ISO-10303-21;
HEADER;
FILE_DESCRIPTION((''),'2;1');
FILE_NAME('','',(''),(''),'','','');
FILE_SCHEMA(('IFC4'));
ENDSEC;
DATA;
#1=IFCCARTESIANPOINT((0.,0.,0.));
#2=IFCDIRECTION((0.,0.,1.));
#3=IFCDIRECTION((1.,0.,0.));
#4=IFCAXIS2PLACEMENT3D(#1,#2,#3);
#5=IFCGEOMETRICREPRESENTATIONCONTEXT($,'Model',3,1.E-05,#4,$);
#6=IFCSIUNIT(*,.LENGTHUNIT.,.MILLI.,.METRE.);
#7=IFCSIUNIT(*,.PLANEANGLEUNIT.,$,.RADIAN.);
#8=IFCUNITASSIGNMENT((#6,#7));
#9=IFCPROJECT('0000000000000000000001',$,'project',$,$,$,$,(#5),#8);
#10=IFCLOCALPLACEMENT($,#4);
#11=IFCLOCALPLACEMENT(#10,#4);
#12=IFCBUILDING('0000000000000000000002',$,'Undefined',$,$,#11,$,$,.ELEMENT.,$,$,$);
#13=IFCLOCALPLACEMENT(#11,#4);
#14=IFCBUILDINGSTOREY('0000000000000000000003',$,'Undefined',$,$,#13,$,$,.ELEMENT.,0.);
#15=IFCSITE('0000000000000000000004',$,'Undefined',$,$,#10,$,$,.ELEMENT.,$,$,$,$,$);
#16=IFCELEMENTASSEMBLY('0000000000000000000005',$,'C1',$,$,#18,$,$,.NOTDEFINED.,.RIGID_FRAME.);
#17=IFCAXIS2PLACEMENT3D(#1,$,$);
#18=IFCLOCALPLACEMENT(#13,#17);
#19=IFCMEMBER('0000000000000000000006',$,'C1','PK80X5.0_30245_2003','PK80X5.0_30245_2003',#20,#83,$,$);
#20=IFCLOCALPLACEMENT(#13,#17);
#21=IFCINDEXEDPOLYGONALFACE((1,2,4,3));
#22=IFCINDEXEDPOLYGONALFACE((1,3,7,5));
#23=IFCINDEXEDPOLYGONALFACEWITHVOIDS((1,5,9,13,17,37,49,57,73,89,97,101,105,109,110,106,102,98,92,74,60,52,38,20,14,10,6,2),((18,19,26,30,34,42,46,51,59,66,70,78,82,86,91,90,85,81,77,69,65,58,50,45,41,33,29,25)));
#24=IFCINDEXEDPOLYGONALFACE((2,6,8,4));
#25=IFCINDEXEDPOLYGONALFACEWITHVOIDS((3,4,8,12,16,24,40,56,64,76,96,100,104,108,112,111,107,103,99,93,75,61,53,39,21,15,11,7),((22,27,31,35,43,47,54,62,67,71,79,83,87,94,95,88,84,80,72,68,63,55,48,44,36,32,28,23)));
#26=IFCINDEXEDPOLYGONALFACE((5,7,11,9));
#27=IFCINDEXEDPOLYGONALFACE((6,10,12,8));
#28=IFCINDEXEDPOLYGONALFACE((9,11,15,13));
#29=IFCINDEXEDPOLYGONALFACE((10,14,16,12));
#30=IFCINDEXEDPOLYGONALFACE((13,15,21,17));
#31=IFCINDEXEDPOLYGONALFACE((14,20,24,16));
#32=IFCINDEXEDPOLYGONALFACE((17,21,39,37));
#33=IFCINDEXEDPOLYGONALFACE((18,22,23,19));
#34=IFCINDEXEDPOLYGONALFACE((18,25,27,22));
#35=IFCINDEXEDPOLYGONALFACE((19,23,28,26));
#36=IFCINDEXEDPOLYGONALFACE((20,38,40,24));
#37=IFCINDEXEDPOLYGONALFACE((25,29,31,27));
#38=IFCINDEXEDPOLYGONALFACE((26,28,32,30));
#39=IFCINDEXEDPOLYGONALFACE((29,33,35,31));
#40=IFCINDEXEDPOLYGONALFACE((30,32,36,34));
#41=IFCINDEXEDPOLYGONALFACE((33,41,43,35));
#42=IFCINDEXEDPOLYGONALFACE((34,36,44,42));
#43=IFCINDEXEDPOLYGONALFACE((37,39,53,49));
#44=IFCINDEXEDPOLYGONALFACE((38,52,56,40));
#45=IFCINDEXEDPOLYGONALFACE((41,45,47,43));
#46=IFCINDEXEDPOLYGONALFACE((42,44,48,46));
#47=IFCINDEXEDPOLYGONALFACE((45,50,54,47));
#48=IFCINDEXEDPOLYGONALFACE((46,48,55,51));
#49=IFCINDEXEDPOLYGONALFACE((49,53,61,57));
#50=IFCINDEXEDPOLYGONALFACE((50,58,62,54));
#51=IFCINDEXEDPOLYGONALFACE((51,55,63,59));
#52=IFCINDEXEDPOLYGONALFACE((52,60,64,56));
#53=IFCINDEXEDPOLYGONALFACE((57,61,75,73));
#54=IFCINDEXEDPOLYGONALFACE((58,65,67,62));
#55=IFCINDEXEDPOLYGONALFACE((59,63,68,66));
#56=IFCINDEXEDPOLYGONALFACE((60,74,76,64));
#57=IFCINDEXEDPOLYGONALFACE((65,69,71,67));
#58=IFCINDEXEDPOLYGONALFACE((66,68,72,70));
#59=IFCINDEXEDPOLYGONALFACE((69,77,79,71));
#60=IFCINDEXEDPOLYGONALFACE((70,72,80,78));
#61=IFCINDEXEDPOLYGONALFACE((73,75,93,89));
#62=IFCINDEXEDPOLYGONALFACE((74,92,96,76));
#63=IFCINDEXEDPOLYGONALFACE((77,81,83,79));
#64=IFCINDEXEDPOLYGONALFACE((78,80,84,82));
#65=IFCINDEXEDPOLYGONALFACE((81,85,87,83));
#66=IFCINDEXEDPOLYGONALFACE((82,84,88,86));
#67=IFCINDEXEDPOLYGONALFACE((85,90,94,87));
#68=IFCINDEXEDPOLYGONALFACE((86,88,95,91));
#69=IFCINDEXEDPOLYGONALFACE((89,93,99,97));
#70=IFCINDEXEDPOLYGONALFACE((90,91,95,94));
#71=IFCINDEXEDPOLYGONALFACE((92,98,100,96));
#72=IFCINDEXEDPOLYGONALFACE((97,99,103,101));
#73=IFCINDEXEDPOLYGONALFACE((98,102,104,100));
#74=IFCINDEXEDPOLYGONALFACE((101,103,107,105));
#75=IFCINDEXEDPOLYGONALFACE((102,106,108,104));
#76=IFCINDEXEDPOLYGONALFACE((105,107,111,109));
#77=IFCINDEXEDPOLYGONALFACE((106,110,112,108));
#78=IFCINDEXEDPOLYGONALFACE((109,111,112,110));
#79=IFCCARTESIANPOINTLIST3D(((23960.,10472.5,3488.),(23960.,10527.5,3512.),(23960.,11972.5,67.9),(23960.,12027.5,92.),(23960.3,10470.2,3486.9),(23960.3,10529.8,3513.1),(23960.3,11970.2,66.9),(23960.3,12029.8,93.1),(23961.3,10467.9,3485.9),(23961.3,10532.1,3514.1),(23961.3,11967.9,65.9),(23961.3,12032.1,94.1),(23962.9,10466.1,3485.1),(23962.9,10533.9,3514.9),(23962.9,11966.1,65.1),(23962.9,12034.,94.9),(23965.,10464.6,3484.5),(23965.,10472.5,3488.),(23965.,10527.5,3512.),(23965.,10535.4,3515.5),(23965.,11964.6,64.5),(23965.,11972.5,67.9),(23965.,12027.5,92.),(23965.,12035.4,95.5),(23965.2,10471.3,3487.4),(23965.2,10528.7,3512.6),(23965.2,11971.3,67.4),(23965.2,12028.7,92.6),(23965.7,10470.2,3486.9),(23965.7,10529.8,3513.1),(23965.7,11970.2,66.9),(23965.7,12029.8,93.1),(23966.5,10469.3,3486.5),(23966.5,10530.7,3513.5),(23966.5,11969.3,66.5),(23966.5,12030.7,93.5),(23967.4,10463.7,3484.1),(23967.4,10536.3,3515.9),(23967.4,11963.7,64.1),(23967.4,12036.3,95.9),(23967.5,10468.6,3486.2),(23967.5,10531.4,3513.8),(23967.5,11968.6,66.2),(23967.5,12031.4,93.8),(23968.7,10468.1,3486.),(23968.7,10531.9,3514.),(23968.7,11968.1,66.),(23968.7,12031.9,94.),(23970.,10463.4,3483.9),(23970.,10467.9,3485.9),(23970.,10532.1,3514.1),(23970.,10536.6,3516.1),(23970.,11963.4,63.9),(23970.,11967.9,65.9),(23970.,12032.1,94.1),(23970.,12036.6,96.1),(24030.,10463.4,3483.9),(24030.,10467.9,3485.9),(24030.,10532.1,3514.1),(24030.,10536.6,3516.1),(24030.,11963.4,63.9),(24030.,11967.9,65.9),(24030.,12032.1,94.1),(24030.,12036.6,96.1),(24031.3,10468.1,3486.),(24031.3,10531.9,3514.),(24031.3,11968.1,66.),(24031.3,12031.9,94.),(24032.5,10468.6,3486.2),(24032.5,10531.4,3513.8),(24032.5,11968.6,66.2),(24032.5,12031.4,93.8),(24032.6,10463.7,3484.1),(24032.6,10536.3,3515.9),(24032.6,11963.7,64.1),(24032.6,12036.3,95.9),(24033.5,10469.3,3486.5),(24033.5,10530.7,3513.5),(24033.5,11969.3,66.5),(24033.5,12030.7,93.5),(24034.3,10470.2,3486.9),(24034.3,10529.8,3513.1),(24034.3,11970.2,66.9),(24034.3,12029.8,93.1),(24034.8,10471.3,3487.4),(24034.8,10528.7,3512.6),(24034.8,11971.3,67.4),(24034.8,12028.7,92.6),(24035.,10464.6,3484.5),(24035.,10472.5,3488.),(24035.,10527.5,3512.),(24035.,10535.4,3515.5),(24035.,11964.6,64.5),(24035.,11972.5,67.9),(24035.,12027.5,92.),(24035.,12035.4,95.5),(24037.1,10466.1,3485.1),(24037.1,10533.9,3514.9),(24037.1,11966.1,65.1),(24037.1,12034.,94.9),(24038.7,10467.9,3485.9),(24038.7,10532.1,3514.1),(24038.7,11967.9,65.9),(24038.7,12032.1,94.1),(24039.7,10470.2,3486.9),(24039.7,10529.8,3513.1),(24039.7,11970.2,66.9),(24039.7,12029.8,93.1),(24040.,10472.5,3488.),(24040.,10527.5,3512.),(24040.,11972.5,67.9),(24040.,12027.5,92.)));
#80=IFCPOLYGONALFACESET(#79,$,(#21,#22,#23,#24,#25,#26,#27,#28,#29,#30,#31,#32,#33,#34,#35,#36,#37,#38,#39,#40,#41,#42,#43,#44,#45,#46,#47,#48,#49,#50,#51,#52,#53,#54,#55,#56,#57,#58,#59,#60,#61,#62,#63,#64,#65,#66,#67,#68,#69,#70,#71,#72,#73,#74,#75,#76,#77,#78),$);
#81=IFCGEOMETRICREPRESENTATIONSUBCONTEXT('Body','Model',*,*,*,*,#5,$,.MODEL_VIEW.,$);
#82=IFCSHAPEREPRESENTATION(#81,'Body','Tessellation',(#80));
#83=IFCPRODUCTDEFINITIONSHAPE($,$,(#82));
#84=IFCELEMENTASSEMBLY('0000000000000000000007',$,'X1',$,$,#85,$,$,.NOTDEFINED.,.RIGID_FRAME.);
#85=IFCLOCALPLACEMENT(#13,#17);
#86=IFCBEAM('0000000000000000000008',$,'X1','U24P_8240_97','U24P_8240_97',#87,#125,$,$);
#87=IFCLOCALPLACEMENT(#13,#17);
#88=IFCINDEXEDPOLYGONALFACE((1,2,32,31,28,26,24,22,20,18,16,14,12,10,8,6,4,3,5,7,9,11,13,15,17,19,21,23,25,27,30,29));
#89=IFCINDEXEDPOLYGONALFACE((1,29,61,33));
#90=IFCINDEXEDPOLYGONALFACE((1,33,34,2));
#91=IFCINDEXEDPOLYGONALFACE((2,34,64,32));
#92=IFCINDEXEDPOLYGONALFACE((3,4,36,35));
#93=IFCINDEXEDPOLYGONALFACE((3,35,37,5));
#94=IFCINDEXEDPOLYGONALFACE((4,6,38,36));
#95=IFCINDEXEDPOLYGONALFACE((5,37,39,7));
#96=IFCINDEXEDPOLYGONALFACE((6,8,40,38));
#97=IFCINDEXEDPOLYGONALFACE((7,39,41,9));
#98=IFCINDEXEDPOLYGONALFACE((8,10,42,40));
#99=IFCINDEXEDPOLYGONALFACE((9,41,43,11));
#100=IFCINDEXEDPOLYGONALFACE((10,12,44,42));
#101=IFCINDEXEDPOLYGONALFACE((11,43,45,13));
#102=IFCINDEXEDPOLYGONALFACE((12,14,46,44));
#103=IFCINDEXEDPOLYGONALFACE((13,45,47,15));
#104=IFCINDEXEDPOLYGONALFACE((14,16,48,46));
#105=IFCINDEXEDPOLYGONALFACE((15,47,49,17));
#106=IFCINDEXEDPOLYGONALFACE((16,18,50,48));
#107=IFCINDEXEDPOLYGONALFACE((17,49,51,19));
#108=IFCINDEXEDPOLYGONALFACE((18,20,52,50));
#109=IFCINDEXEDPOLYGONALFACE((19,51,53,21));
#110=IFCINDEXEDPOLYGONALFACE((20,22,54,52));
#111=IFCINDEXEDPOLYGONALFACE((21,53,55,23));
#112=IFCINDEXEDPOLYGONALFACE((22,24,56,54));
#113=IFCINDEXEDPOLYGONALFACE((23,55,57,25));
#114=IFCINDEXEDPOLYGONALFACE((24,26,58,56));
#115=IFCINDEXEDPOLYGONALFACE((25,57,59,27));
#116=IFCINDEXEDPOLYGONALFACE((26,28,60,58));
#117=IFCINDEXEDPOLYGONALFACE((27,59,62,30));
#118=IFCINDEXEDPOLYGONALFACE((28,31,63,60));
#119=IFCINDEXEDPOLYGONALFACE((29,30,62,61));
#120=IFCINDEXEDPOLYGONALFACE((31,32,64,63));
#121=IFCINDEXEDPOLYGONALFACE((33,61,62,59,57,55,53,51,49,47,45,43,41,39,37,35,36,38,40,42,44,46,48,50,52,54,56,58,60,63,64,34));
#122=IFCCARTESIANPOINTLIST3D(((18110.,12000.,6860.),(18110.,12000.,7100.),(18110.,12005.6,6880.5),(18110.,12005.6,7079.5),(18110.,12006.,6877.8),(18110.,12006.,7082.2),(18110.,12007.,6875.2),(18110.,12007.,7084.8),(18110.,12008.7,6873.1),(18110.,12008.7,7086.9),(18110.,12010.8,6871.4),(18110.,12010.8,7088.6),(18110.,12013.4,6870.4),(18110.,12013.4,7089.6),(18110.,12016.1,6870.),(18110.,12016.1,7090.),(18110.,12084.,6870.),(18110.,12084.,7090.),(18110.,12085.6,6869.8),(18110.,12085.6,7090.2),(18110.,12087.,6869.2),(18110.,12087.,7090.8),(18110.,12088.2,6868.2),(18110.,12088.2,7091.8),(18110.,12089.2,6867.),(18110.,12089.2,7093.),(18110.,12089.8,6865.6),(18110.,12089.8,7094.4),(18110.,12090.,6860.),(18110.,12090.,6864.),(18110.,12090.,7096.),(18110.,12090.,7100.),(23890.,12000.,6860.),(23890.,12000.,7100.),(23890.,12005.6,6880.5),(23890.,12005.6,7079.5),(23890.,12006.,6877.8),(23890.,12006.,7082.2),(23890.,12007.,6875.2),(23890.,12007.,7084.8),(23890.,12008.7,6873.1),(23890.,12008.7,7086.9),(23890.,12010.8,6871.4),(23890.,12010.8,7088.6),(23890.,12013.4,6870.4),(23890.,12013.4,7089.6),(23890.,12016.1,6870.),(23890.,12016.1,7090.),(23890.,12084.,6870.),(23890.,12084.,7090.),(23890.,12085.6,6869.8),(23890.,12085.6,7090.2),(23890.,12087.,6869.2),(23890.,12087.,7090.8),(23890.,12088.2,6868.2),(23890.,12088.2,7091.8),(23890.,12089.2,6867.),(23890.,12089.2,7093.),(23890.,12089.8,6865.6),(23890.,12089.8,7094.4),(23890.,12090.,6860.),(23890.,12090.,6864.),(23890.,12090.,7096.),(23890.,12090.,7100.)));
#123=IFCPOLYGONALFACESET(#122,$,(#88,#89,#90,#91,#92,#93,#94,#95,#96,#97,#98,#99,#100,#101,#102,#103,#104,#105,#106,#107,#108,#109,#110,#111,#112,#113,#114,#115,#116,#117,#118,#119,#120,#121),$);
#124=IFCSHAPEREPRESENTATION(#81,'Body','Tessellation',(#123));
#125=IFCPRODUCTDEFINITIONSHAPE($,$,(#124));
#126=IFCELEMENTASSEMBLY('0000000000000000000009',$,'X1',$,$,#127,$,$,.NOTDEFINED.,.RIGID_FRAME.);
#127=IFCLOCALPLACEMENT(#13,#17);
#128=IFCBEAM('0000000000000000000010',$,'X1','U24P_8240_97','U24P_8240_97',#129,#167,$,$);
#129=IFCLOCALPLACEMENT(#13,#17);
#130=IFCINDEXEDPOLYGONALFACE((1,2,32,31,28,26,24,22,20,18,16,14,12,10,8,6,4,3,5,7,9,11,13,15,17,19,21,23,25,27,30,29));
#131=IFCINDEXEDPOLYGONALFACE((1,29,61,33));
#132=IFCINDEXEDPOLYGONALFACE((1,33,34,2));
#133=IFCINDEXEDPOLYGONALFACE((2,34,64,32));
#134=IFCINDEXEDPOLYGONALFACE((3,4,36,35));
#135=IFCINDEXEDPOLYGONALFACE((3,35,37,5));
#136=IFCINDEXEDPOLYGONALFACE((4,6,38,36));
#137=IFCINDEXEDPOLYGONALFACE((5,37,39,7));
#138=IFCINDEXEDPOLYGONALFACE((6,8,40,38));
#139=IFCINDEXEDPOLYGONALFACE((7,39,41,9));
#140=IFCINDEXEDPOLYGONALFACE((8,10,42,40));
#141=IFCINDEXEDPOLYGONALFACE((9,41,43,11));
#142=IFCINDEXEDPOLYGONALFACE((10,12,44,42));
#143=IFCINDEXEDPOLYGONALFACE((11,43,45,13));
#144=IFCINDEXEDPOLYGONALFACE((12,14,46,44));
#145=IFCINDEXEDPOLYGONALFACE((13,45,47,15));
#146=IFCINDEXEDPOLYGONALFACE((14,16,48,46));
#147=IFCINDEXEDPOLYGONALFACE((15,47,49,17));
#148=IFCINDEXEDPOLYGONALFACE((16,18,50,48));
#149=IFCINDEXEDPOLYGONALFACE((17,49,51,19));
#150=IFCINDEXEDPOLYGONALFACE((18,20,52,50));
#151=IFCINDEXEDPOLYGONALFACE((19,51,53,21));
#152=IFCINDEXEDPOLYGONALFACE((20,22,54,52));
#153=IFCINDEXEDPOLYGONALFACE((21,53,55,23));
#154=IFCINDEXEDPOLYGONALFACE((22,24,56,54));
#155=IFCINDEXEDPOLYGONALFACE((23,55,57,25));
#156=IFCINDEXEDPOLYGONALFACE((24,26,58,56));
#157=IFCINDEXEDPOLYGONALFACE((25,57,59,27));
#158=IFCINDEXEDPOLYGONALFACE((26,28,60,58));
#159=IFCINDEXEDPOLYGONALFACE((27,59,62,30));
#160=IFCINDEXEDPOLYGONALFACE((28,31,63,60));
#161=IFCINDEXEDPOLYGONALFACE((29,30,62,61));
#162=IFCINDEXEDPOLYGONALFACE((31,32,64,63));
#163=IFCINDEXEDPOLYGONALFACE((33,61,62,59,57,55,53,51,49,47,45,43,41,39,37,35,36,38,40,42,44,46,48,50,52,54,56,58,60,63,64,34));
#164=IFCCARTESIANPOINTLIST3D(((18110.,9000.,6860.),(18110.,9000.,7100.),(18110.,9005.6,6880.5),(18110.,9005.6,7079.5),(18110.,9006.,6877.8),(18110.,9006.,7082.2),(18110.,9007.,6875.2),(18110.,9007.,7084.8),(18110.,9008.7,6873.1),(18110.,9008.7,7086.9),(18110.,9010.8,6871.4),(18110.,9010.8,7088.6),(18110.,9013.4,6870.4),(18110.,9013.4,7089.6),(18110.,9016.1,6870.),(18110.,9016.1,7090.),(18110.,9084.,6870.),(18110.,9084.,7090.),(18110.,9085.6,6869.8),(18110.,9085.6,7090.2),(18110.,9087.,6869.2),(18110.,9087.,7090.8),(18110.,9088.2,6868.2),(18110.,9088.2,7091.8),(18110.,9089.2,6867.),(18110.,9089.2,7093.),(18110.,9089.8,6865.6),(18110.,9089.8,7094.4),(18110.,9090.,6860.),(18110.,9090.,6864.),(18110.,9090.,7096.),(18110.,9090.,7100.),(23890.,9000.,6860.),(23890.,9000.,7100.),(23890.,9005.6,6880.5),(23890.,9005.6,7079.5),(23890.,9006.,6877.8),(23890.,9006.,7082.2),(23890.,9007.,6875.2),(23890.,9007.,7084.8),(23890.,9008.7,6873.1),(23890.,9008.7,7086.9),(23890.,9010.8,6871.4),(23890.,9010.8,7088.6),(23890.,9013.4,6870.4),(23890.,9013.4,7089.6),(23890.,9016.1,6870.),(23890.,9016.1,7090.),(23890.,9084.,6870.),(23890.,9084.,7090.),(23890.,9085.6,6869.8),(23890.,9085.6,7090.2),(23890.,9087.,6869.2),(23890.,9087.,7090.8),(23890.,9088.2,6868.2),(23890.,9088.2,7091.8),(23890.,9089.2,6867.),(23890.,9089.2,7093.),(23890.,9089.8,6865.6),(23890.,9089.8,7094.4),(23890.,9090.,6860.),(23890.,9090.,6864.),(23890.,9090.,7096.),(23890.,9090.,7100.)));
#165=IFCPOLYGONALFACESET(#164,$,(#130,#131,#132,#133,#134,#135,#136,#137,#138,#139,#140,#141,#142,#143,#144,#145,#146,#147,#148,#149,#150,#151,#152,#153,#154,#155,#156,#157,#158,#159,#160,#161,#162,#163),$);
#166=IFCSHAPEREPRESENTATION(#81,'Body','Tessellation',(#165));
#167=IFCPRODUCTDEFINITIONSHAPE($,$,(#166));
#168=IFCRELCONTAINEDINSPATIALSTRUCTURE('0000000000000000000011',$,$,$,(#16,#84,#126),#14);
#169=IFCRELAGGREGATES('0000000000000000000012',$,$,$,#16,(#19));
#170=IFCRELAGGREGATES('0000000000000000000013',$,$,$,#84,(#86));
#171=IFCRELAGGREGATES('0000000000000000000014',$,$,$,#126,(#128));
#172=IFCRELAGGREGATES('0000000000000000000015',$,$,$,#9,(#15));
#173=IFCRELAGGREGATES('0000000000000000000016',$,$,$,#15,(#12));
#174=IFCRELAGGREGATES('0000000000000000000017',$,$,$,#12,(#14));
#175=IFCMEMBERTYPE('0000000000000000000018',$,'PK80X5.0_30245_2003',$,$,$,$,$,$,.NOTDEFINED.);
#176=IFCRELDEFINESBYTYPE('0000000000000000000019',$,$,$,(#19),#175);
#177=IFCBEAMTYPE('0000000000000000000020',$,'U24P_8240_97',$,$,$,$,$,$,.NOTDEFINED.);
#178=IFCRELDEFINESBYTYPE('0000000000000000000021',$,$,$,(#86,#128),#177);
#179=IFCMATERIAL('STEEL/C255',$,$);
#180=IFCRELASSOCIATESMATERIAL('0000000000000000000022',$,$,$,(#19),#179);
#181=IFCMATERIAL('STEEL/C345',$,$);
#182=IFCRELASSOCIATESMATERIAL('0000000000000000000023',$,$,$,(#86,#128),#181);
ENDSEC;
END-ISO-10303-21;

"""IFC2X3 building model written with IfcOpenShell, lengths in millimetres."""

from ifc_helpers import new_model, si_unit, frame, origin_with_axes, origin_2d_with_axis, place, context, subcontext, project, spatial, hollow_rectangle, u_section, extrude, material, type_object, element, aggregate, save


model = new_model("IFC2X3")

# Units and contexts
model_context = context("Model", 3, precision=1e-05, world=origin_with_axes())
body_context = subcontext(model_context, "Body", "Model", "MODEL_VIEW")
ifc_project = project(units=[si_unit("LENGTHUNIT", "METRE", prefix="MILLI"), si_unit("PLANEANGLEUNIT", "RADIAN")], contexts=[model_context])

# Site, building, storey
site_placement = place(None, origin_with_axes())
site = spatial("IfcSite", under=ifc_project, at=site_placement, Name="Undefined", CompositionType="ELEMENT")
building_placement = place(site_placement, origin_with_axes())
building = spatial("IfcBuilding", under=site, at=building_placement, Name="Undefined", CompositionType="ELEMENT")
storey_placement = place(building_placement, origin_with_axes())
storey = spatial("IfcBuildingStorey", under=building, at=storey_placement, Name="Undefined", CompositionType="ELEMENT", Elevation=0.0)

# Shared definitions
ifc_material_1 = material(Name="STEEL/C345")

# Shared definitions
ifc_material_2 = material(Name="STEEL/C255")

# Element assembly, member
member_type = type_object("IfcMemberType", Name="PK80X5.0_30245_2003", PredefinedType="NOTDEFINED")
assembly_1_placement = place(storey_placement, origin_with_axes())
assembly_1 = element("IfcElementAssembly", 1, at=assembly_1_placement, inside=storey, Name="C1", AssemblyPlace="NOTDEFINED", PredefinedType="RIGID_FRAME")
member_1_placement = place(assembly_1_placement, frame((24000.0, 12000.0, 80.0), z_axis=(0.0, -0.915788, -0.401661), x_axis=(0.0, -0.401661, 0.915788)))
member_1 = element("IfcMember", 2, at=member_1_placement, type_object=member_type, material=ifc_material_2, Name="C1", Description="PK80X5.0_30245_2003", ObjectType="PK80X5.0_30245_2003", context=body_context, shape_type="SweptSolid", body=[
    extrude(hollow_rectangle(XDim=80.0, YDim=80.0, WallThickness=5.0, InnerFilletRadius=5.0, OuterFilletRadius=10.0, at=origin_2d_with_axis()), frame((3734.5, 0.0, 0.0), z_axis=(-1.0, 0.0, 0.0), x_axis=(0.0, -1.0, 0.0)), (0.0, 0.0, 1.0), 3734.5),
])
aggregate(assembly_1, [member_1])

# Element assemblies, beams
assembly_2_placement = place(storey_placement, origin_with_axes())
assembly_2 = element("IfcElementAssembly", 3, at=assembly_2_placement, inside=storey, Name="X1", AssemblyPlace="NOTDEFINED", PredefinedType="RIGID_FRAME")
beam_type_1 = type_object("IfcBeamType", Name="U24P_8240_97", PredefinedType="NOTDEFINED")
beam_1_placement = place(assembly_2_placement, frame((18110.0, 12045.0, 6980.0), z_axis=(0.0, 0.0, -1.0), x_axis=(1.0, 0.0, 0.0)))
beam_1 = element("IfcBeam", 4, at=beam_1_placement, type_object=beam_type_1, material=ifc_material_1, Name="X1", Description="U24P_8240_97", ObjectType="U24P_8240_97", context=body_context, shape_type="SweptSolid", body=[
    extrude(u_section(Depth=240.0, FlangeWidth=90.0, WebThickness=5.6, FlangeThickness=10.0, FilletRadius=10.5, EdgeRadius=6.0, at=origin_2d_with_axis()), frame((5780.0, 0.0, 0.0), z_axis=(-1.0, 0.0, 0.0), x_axis=(0.0, -1.0, 0.0)), (0.0, 0.0, 1.0), 5780.0),
])
aggregate(assembly_2, [beam_1])
assembly_3_placement = place(storey_placement, origin_with_axes())
assembly_3 = element("IfcElementAssembly", 5, at=assembly_3_placement, inside=storey, Name="X1", AssemblyPlace="NOTDEFINED", PredefinedType="RIGID_FRAME")
beam_2_placement = place(assembly_3_placement, frame((18110.0, 9045.0, 6980.0), z_axis=(0.0, 0.0, -1.0), x_axis=(1.0, 0.0, 0.0)))
beam_2 = element("IfcBeam", 6, at=beam_2_placement, type_object=beam_type_1, material=ifc_material_1, Name="X1", Description="U24P_8240_97", ObjectType="U24P_8240_97", context=body_context, shape_type="SweptSolid", body=[
    extrude(u_section(Depth=240.0, FlangeWidth=90.0, WebThickness=5.6, FlangeThickness=10.0, FilletRadius=10.5, EdgeRadius=6.0, at=origin_2d_with_axis()), frame((5780.0, 0.0, 0.0), z_axis=(-1.0, 0.0, 0.0), x_axis=(0.0, -1.0, 0.0)), (0.0, 0.0, 1.0), 5780.0),
])
aggregate(assembly_3, [beam_2])

save(model, "model.ifc")
